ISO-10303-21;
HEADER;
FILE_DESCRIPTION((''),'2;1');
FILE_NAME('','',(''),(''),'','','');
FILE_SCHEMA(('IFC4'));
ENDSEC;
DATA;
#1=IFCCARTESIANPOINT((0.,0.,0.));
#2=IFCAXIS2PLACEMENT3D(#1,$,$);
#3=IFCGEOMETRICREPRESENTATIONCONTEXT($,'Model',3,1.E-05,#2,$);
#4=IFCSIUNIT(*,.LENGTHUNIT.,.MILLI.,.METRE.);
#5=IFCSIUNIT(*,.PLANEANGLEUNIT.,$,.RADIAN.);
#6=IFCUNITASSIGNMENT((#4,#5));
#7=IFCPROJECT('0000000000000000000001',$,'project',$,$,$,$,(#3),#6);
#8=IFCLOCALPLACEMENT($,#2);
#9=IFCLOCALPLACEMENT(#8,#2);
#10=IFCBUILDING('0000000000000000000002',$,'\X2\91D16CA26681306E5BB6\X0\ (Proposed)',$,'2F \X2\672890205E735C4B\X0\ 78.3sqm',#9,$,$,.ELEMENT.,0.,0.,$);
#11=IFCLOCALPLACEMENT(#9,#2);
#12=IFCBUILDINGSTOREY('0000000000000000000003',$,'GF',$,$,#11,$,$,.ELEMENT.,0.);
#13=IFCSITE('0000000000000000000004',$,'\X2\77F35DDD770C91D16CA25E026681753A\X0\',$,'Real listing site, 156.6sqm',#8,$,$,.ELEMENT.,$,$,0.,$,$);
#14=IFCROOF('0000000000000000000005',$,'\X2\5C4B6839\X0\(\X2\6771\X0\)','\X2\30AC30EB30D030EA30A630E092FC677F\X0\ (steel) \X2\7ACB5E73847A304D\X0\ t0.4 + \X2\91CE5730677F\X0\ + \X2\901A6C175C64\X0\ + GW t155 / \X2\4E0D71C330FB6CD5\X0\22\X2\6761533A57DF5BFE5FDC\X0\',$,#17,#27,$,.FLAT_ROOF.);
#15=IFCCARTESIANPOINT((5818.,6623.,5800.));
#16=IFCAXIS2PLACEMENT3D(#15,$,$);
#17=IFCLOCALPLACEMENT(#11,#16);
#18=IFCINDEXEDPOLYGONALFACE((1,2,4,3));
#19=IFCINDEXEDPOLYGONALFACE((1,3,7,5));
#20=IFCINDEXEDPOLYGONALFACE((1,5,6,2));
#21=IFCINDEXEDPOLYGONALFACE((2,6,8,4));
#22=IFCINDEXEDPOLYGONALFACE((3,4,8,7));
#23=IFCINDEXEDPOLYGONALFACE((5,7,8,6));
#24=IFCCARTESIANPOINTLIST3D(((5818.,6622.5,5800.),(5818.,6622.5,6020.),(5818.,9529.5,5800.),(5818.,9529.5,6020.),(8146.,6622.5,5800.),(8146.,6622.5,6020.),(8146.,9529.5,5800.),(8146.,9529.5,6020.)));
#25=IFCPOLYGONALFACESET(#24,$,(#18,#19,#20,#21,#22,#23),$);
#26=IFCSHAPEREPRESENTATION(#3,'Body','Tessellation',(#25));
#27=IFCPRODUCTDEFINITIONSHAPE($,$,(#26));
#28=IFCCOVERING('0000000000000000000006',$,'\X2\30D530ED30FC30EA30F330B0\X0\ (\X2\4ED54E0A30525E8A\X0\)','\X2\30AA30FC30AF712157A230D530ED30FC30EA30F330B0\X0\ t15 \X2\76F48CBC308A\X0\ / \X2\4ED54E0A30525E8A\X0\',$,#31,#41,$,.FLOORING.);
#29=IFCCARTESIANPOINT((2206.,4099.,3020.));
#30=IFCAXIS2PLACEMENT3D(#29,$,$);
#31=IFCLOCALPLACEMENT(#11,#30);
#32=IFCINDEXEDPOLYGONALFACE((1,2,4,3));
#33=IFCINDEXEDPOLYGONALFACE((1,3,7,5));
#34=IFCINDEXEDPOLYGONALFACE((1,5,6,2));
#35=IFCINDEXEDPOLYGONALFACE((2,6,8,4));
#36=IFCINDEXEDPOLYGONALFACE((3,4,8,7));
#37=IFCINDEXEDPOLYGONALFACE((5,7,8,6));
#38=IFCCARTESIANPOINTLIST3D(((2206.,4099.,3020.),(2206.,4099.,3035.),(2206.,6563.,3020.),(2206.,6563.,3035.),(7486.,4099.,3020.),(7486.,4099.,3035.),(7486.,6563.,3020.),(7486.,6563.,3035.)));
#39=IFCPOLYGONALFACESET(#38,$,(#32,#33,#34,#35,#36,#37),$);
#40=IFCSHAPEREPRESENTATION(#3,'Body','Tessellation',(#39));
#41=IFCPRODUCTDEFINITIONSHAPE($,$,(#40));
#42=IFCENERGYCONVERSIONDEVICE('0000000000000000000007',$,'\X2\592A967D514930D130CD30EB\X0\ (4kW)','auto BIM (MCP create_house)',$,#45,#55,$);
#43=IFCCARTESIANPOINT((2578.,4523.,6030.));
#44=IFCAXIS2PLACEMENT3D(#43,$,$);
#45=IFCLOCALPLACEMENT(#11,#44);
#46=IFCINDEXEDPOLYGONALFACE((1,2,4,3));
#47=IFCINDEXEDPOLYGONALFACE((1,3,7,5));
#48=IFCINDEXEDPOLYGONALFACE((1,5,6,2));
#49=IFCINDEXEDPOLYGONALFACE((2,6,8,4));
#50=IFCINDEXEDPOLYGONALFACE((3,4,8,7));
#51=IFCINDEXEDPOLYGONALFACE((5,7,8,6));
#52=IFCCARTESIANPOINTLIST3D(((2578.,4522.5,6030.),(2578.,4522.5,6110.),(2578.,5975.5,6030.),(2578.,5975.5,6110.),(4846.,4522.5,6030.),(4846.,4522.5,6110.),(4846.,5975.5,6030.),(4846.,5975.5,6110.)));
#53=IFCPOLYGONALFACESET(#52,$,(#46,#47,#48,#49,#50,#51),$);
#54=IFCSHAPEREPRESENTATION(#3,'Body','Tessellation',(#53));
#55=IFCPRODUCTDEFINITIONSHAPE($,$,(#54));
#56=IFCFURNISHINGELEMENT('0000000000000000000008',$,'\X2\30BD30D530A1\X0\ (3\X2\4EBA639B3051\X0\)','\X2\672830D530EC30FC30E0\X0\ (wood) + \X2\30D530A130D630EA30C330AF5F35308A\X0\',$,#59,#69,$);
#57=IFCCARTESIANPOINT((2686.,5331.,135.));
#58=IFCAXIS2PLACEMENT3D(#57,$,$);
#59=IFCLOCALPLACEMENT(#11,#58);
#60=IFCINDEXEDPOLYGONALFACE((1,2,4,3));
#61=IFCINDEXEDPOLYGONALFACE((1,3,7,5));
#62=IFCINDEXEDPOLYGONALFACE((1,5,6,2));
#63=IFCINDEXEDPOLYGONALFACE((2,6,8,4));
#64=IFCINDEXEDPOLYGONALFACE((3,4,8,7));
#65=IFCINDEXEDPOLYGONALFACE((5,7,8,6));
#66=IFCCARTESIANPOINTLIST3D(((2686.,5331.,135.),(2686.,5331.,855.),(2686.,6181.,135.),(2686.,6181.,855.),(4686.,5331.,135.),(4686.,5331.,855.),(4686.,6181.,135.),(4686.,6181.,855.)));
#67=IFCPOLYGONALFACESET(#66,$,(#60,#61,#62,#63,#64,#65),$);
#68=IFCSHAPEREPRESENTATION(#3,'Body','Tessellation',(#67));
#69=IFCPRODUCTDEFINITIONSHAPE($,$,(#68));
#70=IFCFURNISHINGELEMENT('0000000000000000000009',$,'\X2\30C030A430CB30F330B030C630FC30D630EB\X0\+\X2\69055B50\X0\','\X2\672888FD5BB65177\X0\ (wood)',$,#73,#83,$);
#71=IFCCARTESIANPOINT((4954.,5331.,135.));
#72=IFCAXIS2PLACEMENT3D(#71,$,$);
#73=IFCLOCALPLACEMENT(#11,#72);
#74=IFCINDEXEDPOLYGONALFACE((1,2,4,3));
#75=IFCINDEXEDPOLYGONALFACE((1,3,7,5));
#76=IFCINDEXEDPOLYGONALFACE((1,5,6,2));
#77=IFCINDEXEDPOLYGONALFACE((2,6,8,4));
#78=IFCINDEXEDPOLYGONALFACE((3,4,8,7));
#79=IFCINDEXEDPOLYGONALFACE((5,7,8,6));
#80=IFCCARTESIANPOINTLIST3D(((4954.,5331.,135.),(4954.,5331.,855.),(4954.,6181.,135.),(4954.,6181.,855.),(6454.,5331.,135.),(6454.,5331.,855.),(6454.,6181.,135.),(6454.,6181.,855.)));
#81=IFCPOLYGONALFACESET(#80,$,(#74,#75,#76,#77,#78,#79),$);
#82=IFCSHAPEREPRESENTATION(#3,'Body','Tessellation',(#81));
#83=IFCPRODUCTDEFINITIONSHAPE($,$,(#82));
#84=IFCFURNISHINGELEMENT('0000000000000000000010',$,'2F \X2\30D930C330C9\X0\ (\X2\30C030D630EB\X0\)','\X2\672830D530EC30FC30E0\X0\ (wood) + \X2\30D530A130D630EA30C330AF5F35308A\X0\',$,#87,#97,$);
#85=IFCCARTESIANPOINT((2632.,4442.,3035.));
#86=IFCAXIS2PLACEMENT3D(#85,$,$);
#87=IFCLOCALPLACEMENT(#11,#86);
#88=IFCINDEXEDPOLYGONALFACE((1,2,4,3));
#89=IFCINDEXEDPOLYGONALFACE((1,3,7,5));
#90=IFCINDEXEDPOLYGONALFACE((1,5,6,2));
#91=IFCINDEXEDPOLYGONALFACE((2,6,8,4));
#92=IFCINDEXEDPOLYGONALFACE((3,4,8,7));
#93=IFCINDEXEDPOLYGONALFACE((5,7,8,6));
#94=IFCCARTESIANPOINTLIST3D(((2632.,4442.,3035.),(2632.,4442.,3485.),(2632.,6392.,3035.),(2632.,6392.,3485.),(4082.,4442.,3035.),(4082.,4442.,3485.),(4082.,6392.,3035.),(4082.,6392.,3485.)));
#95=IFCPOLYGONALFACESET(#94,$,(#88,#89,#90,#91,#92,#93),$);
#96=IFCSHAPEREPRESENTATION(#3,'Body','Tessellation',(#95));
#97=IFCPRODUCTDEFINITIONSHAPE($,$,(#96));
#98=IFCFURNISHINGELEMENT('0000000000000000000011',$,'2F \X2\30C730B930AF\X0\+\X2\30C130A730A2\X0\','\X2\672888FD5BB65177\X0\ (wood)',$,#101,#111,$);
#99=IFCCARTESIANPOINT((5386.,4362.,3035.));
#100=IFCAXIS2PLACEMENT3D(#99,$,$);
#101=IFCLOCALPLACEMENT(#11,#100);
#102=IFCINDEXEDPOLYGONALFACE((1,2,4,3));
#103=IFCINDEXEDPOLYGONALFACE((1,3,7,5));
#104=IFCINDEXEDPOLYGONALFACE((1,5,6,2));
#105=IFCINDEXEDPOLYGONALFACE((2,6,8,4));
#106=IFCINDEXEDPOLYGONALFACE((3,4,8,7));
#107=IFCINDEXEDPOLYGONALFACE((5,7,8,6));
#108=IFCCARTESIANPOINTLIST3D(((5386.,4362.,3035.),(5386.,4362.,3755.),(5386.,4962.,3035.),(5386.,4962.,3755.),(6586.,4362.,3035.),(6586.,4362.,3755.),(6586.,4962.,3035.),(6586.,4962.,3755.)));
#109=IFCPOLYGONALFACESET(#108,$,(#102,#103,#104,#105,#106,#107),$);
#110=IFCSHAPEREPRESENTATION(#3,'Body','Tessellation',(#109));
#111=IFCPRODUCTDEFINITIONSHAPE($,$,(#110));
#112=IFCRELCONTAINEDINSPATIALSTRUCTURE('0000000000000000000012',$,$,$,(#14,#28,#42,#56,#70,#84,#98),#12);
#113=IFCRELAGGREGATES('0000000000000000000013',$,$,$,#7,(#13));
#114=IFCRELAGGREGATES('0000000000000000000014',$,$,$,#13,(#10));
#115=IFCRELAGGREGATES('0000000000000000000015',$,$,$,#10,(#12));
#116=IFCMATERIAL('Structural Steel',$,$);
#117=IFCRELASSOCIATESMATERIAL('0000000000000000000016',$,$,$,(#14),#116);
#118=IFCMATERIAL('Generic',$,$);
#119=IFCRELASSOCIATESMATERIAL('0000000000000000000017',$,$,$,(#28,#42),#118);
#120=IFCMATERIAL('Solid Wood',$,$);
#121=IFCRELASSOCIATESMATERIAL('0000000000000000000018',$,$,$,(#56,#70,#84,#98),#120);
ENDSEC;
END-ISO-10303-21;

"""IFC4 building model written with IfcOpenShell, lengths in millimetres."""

from ifc_helpers import new_model, si_unit, frame, frame_2d, origin, place, context, project, spatial, rectangle, extrude, material, element, save


model = new_model("IFC4")

# Units and contexts
model_context = context("Model", 3, precision=1e-05, world=origin())
ifc_project = project(units=[si_unit("LENGTHUNIT", "METRE", prefix="MILLI"), si_unit("PLANEANGLEUNIT", "RADIAN")], contexts=[model_context])

# Site, building, storey
site_placement = place(None, origin())
site = spatial("IfcSite", under=ifc_project, at=site_placement, Name="石川県金沢市暁町", ObjectType="Real listing site, 156.6sqm", CompositionType="ELEMENT", RefElevation=0.0)
building_placement = place(site_placement, origin())
building = spatial("IfcBuilding", under=site, at=building_placement, Name="金沢暁の家 (Proposed)", ObjectType="2F 木造平屋 78.3sqm", CompositionType="ELEMENT", ElevationOfRefHeight=0.0, ElevationOfTerrain=0.0)
storey_placement = place(building_placement, origin())
storey = spatial("IfcBuildingStorey", under=building, at=storey_placement, Name="GF", CompositionType="ELEMENT", Elevation=0.0)

# Shared definitions
ifc_material_1 = material(Name="Solid Wood")

# Roof
ifc_material_2 = material(Name="Structural Steel")
roof_1_placement = place(storey_placement, frame((5818.0, 6623.0, 5800.0)))
element("IfcRoof", 1, at=roof_1_placement, inside=storey, material=ifc_material_2, Name="屋根(東)", Description="ガルバリウム鋼板 (steel) 立平葺き t0.4 + 野地板 + 通気層 + GW t155 / 不燃・法22条区域対応", PredefinedType="FLAT_ROOF", context=model_context, shape_type="SweptSolid", body=[
    extrude(rectangle(XDim=2328.0, YDim=2907.0, at=frame_2d((1164.0, 1453.0))), frame((5818.0, 6623.0, 5800.0)), (0.0, 0.0, 1.0), 220.0),
])

# Covering
ifc_material_3 = material(Name="Generic")
covering_placement = place(storey_placement, frame((2206.0, 4099.0, 3020.0)))
element("IfcCovering", 2, at=covering_placement, inside=storey, material=ifc_material_3, Name="フローリング (仕上げ床)", Description="オーク無垢フローリング t15 直貼り / 仕上げ床", PredefinedType="FLOORING", context=model_context, shape_type="SweptSolid", body=[
    extrude(rectangle(XDim=5280.0, YDim=2464.0, at=frame_2d((2640.0, 1232.0))), frame((2206.0, 4099.0, 3020.0)), (0.0, 0.0, 1.0), 15.0),
])

# Energy conversion device
energy_conversion_device_placement = place(storey_placement, frame((2578.0, 4523.0, 6030.0)))
element("IfcEnergyConversionDevice", 3, at=energy_conversion_device_placement, inside=storey, material=ifc_material_3, Name="太陽光パネル (4kW)", Description="auto BIM (MCP create_house)", context=model_context, shape_type="SweptSolid", body=[
    extrude(rectangle(XDim=2268.0, YDim=1453.0, at=frame_2d((1134.0, 726.0))), frame((2578.0, 4523.0, 6030.0)), (0.0, 0.0, 1.0), 80.0),
])

# Furnishing elements
furnishing_1_placement = place(storey_placement, frame((2686.0, 5331.0, 135.0)))
element("IfcFurnishingElement", 4, at=furnishing_1_placement, inside=storey, material=ifc_material_1, Name="ソファ (3人掛け)", Description="木フレーム (wood) + ファブリック張り", context=model_context, shape_type="SweptSolid", body=[
    extrude(rectangle(XDim=2000.0, YDim=850.0, at=frame_2d((1000.0, 425.0))), frame((2686.0, 5331.0, 135.0)), (0.0, 0.0, 1.0), 720.0),
])
furnishing_2_placement = place(storey_placement, frame((4954.0, 5331.0, 135.0)))
element("IfcFurnishingElement", 5, at=furnishing_2_placement, inside=storey, material=ifc_material_1, Name="ダイニングテーブル+椅子", Description="木製家具 (wood)", context=model_context, shape_type="SweptSolid", body=[
    extrude(rectangle(XDim=1500.0, YDim=850.0, at=frame_2d((750.0, 425.0))), frame((4954.0, 5331.0, 135.0)), (0.0, 0.0, 1.0), 720.0),
])
furnishing_3_placement = place(storey_placement, frame((2632.0, 4442.0, 3035.0)))
element("IfcFurnishingElement", 6, at=furnishing_3_placement, inside=storey, material=ifc_material_1, Name="2F ベッド (ダブル)", Description="木フレーム (wood) + ファブリック張り", context=model_context, shape_type="SweptSolid", body=[
    extrude(rectangle(XDim=1450.0, YDim=1950.0, at=frame_2d((725.0, 975.0))), frame((2632.0, 4442.0, 3035.0)), (0.0, 0.0, 1.0), 450.0),
])
furnishing_4_placement = place(storey_placement, frame((5386.0, 4362.0, 3035.0)))
element("IfcFurnishingElement", 7, at=furnishing_4_placement, inside=storey, material=ifc_material_1, Name="2F デスク+チェア", Description="木製家具 (wood)", context=model_context, shape_type="SweptSolid", body=[
    extrude(rectangle(XDim=1200.0, YDim=600.0, at=frame_2d((600.0, 300.0))), frame((5386.0, 4362.0, 3035.0)), (0.0, 0.0, 1.0), 720.0),
])

save(model, "model.ifc")
